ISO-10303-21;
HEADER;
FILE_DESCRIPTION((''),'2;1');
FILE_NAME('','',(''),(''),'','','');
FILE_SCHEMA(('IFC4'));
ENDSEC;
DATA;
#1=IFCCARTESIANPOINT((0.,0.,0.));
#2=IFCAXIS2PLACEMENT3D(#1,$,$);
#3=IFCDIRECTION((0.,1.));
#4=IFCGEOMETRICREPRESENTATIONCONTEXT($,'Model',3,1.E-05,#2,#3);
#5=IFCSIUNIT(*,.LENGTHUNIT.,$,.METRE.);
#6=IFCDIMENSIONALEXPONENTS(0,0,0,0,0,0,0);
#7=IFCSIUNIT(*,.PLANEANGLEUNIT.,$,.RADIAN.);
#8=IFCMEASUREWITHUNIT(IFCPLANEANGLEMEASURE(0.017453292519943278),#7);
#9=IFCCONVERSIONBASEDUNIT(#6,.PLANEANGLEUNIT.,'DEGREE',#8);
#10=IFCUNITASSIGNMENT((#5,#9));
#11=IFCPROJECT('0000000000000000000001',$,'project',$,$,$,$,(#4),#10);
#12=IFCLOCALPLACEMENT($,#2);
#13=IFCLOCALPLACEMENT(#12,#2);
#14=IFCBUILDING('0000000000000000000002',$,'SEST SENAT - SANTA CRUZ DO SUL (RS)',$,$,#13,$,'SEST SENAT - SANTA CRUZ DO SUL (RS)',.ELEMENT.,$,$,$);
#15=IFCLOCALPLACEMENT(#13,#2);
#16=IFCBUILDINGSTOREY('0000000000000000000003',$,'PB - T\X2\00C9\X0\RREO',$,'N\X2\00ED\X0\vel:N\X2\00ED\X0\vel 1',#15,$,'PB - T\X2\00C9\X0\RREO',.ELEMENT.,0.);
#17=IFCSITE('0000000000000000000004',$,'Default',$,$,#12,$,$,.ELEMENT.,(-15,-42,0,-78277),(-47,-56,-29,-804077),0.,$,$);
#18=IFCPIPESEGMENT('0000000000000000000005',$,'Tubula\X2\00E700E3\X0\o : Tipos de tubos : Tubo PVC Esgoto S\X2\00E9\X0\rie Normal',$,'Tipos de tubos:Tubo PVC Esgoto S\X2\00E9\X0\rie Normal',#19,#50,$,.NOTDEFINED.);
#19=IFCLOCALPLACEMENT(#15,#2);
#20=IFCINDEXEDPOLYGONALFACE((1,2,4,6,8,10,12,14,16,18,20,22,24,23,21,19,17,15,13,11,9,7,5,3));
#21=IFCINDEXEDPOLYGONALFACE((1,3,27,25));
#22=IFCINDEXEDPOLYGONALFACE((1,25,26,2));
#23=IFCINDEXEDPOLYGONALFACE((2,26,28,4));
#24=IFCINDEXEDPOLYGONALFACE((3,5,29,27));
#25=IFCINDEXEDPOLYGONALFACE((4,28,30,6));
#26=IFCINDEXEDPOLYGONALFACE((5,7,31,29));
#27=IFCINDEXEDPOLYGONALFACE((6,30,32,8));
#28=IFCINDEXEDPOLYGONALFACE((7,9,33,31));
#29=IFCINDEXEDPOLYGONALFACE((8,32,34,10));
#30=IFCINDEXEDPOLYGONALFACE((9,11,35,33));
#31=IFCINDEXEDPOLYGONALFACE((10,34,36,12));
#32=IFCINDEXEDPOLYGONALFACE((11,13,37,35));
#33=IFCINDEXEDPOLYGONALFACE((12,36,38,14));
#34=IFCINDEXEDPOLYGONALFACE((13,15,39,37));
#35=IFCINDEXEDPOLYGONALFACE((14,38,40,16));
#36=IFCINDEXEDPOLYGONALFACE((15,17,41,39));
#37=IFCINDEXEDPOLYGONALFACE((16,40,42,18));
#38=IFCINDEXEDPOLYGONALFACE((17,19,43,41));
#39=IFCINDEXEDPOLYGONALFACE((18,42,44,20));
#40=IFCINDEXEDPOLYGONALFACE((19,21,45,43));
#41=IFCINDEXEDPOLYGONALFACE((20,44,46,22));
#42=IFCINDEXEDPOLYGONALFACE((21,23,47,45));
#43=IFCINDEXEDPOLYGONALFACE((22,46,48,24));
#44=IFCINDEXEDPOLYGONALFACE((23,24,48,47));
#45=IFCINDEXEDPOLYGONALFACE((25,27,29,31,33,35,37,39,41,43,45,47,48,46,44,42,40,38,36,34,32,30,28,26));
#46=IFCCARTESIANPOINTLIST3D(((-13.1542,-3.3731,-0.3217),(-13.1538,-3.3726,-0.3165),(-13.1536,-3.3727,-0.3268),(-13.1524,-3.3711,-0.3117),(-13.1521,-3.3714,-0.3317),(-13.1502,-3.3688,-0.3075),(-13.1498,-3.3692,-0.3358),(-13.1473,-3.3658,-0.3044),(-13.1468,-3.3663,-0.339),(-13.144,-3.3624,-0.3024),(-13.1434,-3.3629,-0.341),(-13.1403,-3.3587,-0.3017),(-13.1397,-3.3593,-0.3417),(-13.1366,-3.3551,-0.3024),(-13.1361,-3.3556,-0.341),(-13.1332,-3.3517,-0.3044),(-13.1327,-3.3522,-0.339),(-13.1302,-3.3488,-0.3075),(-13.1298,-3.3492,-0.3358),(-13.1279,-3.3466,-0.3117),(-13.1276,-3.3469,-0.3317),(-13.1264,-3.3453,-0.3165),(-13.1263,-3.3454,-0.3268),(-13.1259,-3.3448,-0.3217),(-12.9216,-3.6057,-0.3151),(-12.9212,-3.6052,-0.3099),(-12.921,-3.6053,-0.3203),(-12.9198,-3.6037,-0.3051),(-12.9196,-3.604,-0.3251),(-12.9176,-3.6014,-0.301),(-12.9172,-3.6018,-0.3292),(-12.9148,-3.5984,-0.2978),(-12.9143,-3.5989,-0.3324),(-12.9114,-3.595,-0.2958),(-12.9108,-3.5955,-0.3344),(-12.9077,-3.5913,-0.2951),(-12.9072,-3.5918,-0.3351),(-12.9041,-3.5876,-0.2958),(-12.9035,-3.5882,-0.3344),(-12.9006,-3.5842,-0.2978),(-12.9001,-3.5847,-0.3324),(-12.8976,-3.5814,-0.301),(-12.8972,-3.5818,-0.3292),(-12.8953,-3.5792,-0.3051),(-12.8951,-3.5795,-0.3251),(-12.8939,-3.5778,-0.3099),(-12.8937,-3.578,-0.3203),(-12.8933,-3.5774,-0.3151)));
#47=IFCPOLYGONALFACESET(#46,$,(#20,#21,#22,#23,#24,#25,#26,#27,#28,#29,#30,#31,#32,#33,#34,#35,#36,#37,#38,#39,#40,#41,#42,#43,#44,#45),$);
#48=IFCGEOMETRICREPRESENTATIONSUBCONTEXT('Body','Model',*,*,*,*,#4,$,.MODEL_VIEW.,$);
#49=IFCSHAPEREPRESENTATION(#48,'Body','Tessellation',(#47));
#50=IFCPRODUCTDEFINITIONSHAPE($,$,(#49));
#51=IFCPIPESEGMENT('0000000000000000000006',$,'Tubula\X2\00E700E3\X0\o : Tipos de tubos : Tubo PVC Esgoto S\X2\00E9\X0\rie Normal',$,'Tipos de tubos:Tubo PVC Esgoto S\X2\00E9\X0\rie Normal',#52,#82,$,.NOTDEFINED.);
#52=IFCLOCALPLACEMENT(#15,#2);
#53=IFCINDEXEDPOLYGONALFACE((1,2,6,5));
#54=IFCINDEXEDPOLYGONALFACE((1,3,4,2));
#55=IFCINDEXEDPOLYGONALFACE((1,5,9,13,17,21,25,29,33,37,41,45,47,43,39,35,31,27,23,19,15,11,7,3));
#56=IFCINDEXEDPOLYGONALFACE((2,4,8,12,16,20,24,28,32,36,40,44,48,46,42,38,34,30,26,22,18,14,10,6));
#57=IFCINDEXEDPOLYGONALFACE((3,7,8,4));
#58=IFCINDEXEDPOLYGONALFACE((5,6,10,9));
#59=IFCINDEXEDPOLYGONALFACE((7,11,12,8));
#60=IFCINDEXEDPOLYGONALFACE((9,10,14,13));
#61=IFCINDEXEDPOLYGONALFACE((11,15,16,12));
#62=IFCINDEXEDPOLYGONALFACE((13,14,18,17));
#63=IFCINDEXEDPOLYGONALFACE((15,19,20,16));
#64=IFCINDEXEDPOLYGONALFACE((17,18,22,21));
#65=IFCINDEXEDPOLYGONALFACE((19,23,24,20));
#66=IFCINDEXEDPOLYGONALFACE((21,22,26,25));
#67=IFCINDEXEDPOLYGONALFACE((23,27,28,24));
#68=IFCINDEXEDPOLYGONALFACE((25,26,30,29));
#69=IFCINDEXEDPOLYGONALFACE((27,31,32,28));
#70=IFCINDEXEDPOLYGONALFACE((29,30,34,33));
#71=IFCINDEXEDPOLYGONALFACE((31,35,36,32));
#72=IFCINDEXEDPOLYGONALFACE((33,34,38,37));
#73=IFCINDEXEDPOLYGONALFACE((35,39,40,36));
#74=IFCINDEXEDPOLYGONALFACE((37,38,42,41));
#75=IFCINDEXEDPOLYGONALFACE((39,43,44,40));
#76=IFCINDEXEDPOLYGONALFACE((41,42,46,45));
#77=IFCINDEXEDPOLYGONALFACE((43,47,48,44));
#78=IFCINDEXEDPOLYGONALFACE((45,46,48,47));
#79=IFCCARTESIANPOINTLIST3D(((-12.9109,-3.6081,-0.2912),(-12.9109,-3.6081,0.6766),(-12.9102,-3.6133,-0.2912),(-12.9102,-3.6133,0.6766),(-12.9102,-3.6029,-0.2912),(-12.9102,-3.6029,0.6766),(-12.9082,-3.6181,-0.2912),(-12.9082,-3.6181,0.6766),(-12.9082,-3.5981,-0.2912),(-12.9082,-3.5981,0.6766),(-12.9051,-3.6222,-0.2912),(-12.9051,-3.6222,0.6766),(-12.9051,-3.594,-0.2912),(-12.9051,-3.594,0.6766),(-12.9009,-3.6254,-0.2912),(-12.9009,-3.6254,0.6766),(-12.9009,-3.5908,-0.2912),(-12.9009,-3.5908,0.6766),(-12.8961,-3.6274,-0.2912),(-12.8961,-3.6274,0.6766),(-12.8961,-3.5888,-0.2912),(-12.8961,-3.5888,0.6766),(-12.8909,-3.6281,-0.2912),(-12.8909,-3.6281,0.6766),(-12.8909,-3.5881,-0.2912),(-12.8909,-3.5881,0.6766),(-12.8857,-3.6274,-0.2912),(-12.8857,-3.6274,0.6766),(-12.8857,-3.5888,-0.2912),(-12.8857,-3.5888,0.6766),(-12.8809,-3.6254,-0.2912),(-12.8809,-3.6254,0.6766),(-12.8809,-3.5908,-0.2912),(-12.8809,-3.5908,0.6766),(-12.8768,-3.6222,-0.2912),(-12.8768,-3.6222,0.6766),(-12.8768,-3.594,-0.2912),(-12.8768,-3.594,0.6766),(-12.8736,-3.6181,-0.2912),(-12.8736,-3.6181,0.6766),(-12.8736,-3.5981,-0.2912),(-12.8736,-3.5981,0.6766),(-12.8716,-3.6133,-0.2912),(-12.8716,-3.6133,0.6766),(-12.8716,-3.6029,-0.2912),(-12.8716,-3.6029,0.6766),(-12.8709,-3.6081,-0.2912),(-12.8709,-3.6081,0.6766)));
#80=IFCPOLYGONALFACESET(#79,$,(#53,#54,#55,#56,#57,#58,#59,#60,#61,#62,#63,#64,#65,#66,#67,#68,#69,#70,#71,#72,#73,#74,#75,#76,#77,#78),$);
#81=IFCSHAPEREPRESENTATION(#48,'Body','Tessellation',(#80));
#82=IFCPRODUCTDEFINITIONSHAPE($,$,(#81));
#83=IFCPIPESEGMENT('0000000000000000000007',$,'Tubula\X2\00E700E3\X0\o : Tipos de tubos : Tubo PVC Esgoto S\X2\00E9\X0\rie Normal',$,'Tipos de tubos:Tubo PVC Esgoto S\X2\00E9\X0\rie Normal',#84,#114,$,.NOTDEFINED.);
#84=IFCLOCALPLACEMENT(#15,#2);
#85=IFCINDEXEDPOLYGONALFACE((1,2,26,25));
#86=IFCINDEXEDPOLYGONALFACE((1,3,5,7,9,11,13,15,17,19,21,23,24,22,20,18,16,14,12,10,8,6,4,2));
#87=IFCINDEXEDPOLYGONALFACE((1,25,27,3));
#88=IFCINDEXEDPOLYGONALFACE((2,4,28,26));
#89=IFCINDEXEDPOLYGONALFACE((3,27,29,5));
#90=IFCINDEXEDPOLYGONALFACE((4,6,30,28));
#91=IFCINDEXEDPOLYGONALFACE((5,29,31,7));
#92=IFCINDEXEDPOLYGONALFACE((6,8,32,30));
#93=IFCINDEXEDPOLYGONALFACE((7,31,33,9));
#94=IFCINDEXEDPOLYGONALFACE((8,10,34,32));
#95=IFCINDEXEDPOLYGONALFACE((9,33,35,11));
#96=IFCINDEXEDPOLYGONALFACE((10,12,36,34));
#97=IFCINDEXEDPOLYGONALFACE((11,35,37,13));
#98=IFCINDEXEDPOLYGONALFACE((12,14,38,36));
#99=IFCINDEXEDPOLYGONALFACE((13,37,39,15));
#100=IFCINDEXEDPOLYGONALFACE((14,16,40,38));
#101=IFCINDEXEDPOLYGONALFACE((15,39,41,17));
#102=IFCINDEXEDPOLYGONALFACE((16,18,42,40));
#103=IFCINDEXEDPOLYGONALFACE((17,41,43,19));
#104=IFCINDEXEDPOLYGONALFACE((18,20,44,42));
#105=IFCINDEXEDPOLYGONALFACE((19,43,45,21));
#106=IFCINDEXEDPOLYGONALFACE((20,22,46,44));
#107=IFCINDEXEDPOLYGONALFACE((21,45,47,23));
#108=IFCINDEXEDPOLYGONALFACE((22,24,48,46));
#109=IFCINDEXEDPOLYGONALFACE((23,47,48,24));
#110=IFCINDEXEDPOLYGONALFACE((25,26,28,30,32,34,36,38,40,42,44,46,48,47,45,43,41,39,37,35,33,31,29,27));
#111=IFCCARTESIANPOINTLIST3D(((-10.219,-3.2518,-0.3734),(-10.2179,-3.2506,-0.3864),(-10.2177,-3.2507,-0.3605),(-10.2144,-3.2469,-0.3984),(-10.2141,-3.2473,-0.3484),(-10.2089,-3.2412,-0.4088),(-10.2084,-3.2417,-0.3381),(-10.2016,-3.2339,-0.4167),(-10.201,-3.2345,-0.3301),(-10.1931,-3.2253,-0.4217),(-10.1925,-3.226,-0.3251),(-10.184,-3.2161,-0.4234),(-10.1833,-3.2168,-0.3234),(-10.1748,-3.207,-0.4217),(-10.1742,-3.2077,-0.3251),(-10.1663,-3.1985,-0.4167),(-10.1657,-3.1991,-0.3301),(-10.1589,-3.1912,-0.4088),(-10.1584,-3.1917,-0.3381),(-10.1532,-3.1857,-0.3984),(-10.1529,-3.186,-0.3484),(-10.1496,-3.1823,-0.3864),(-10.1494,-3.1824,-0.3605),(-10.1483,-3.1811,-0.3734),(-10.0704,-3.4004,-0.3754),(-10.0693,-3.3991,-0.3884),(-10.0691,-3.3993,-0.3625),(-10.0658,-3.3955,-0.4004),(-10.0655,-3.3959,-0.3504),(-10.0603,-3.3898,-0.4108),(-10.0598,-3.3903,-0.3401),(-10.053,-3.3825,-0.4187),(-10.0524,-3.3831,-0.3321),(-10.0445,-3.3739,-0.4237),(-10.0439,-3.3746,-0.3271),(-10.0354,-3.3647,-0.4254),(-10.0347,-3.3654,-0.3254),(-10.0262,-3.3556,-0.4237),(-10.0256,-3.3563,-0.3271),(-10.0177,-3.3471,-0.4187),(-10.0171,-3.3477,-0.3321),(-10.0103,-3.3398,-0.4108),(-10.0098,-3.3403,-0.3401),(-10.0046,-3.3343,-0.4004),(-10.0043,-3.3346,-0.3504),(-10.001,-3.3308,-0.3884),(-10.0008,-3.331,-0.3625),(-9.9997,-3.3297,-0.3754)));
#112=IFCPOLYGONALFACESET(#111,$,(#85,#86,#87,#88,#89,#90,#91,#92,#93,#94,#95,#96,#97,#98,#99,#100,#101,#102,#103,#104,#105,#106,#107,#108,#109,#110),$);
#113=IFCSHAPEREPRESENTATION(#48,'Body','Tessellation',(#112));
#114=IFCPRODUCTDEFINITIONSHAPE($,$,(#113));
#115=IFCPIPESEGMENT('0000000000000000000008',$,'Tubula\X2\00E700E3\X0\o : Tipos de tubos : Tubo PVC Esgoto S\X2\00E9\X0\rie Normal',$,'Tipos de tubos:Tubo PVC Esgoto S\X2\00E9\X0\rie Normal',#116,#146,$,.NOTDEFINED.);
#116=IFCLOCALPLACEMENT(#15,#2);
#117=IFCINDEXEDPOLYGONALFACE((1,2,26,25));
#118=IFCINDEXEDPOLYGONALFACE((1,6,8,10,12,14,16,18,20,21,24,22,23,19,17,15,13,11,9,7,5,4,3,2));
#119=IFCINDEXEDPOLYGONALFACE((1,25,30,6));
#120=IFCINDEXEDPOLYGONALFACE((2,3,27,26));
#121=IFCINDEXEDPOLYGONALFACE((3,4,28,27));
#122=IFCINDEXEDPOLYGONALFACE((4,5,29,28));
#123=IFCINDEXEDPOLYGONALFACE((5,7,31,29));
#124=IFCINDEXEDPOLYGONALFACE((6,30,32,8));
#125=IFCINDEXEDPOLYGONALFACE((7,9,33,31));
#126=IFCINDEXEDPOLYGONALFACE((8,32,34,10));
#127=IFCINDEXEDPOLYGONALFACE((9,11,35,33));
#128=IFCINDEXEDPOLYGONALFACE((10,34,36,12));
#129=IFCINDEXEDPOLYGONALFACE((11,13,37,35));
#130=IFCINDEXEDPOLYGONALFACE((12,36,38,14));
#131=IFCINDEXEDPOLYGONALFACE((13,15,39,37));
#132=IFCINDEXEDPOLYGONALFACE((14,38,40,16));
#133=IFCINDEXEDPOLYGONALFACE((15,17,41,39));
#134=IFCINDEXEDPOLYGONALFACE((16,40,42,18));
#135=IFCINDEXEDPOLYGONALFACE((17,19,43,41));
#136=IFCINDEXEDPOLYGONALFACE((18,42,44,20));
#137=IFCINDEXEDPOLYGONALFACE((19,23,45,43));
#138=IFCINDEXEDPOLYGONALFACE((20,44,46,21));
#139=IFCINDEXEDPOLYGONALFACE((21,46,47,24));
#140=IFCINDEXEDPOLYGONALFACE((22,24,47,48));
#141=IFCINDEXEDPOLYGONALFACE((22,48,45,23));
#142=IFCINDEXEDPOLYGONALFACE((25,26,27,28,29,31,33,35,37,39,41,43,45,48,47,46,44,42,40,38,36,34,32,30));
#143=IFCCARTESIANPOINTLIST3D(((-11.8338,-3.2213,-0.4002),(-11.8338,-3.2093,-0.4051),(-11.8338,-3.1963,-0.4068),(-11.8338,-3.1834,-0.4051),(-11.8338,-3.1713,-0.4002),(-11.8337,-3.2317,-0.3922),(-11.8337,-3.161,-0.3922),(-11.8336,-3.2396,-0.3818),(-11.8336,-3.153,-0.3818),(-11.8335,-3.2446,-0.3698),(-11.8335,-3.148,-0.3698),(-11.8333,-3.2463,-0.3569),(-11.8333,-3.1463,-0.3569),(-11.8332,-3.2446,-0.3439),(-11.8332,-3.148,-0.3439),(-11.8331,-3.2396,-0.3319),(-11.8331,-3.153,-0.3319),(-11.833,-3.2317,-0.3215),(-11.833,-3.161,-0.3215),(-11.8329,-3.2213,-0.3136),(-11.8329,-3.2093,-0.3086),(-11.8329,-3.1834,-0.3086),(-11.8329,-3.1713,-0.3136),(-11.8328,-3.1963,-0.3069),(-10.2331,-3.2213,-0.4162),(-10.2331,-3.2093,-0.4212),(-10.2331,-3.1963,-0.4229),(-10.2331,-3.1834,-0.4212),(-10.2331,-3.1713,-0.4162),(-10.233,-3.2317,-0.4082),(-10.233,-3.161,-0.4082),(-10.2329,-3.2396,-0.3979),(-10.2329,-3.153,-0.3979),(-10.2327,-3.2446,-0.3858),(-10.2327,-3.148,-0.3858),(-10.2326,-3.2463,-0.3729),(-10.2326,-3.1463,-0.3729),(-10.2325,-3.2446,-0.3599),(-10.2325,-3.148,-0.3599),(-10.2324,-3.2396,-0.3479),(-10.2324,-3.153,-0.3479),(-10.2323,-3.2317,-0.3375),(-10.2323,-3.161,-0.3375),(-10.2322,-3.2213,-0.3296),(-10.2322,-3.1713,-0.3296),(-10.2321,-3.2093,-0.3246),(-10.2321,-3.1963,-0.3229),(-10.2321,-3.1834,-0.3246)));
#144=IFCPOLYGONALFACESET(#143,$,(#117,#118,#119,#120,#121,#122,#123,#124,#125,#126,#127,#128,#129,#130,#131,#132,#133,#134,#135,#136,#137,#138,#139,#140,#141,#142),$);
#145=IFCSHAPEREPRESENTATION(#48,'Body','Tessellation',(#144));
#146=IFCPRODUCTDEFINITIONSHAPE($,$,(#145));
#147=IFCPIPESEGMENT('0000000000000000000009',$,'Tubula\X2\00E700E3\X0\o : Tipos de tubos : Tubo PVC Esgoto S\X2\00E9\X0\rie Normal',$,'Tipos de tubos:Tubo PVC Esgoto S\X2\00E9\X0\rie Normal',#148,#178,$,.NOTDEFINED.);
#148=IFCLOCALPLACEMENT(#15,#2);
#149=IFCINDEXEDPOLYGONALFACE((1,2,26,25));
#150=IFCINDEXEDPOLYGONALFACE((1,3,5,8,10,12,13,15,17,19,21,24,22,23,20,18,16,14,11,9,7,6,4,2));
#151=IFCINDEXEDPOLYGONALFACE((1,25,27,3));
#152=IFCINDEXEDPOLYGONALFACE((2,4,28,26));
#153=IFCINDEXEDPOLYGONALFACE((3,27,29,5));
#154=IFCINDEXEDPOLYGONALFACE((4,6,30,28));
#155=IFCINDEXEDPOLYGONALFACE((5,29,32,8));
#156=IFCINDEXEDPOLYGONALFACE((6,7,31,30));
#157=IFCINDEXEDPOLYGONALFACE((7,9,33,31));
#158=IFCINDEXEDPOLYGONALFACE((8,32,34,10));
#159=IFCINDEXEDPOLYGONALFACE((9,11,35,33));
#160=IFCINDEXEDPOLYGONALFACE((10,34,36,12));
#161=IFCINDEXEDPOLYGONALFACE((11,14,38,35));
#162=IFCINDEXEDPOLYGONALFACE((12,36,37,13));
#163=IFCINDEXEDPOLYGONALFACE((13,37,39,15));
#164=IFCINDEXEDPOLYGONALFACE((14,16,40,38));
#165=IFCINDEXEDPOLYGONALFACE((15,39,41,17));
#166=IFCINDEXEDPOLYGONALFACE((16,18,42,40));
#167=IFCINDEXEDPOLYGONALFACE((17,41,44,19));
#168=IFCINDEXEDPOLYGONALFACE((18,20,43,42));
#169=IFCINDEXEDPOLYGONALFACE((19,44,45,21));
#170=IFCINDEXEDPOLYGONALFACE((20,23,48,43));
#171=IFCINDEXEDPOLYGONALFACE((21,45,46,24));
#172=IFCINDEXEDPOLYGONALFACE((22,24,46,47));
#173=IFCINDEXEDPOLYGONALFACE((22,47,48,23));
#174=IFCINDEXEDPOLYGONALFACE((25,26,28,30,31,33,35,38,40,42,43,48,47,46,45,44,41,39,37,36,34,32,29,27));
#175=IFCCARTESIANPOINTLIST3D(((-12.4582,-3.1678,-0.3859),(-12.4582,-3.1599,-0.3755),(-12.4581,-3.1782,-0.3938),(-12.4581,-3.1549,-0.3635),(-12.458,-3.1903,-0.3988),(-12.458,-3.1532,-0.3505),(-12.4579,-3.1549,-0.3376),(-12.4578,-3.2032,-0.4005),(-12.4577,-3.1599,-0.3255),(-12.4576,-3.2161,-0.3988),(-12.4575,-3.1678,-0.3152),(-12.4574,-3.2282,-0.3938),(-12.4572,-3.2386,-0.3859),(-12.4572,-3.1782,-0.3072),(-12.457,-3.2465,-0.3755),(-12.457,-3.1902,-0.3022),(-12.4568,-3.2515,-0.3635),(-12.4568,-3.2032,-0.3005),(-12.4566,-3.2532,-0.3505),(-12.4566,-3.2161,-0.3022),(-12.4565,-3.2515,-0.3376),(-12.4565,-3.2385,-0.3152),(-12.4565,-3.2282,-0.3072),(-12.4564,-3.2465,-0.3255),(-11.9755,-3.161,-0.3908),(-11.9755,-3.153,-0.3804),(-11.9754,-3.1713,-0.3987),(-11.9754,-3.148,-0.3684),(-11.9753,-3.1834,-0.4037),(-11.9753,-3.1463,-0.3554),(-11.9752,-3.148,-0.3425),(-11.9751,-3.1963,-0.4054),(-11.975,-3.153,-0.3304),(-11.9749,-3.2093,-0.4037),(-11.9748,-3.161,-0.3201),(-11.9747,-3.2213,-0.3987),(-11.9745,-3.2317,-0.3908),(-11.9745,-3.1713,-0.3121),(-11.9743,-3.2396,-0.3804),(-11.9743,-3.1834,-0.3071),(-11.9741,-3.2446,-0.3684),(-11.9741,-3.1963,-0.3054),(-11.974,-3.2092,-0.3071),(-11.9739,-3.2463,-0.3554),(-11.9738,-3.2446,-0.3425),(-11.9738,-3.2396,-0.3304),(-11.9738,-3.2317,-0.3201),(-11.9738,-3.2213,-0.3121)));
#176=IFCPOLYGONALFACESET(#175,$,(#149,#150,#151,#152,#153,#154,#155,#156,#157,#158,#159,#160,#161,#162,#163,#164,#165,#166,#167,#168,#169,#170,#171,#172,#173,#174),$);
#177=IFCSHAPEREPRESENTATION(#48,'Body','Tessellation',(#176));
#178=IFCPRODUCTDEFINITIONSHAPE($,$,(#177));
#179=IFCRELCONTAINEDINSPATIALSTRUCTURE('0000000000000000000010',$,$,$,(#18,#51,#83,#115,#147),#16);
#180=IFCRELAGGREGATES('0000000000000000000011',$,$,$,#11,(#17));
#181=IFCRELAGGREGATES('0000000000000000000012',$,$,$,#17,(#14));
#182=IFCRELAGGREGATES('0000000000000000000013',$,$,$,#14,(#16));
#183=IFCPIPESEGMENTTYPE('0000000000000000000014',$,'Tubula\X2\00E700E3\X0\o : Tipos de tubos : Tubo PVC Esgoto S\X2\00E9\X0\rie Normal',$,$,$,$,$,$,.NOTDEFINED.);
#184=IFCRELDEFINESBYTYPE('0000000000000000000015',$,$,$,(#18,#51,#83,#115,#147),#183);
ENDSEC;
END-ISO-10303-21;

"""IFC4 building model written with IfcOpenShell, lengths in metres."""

from ifc_helpers import new_model, entity, si_unit, converted_unit, direction, frame, origin, place, context, subcontext, project, spatial, arc, indexed_curve, outline, extrude, type_object, element, save


model = new_model("IFC4")

# Units and contexts
model_context = context("Model", 3, precision=1e-05, world=origin(), true_north=direction((0.0, 1.0)))
body_context = subcontext(model_context, "Body", "Model", "MODEL_VIEW")
ifc_project = project(units=[si_unit("LENGTHUNIT", "METRE"), converted_unit("PLANEANGLEUNIT", "DEGREE", entity("IfcPlaneAngleMeasure", 0.017453292519943278), si_unit("PLANEANGLEUNIT", "RADIAN"), dimensions=[0, 0, 0, 0, 0, 0, 0])], contexts=[model_context])

# Site, building, storey
site_placement = place(None, origin())
site = spatial("IfcSite", under=ifc_project, at=site_placement, Name="Default", CompositionType="ELEMENT", RefLatitude=(-15, -42, 0, -78277), RefLongitude=(-47, -56, -29, -804077), RefElevation=0.0)
building_placement = place(site_placement, origin())
building = spatial("IfcBuilding", under=site, at=building_placement, Name="SEST SENAT - SANTA CRUZ DO SUL (RS)", LongName="SEST SENAT - SANTA CRUZ DO SUL (RS)", CompositionType="ELEMENT")
storey_placement = place(building_placement, origin())
storey = spatial("IfcBuildingStorey", under=building, at=storey_placement, Name="PB - TÉRREO", ObjectType="Nível:Nível 1", LongName="PB - TÉRREO", CompositionType="ELEMENT", Elevation=0.0)

# Pipe segments
pipe_segment_type_1 = type_object("IfcPipeSegmentType", Name="Tubulação : Tipos de tubos : Tubo PVC Esgoto Série Normal", PredefinedType="NOTDEFINED")
pipe_segment_1_placement = place(storey_placement, frame((-13.1558, -3.6073, -0.3433)))
element("IfcPipeSegment", 1, at=pipe_segment_1_placement, inside=storey, type_object=pipe_segment_type_1, Name="Tubulação : Tipos de tubos : Tubo PVC Esgoto Série Normal", ObjectType="Tipos de tubos:Tubo PVC Esgoto Série Normal", PredefinedType="NOTDEFINED", context=body_context, shape_type="SweptSolid", body=[
    extrude(outline(indexed_curve([(0.02, 0.0), (0.0141, 0.0141), (0.0, 0.02), (-0.0141, 0.0141), (-0.02, 0.0), (-0.0141, -0.0141), (0.0, -0.02), (0.0141, -0.0141)], segments=[arc(1, 2, 3), arc(3, 4, 5), arc(5, 6, 7), arc(7, 8, 1)], self_intersect=False)), frame((0.2483, 0.0157, 0.0282), z_axis=(-0.706965, 0.706965, -0.019996), x_axis=(-0.707107, -0.707107, 0.0)), (0.0, 0.0, 1.0), 0.329),
])
pipe_segment_2_placement = place(storey_placement, frame((-12.9125, -3.6297, -0.2912)))
element("IfcPipeSegment", 2, at=pipe_segment_2_placement, inside=storey, type_object=pipe_segment_type_1, Name="Tubulação : Tipos de tubos : Tubo PVC Esgoto Série Normal", ObjectType="Tipos de tubos:Tubo PVC Esgoto Série Normal", PredefinedType="NOTDEFINED", context=body_context, shape_type="SweptSolid", body=[
    extrude(outline(indexed_curve([(0.02, 0.0), (0.0141, 0.0141), (0.0, 0.02), (-0.0141, 0.0141), (-0.02, 0.0), (-0.0141, -0.0141), (0.0, -0.02), (0.0141, -0.0141)], segments=[arc(1, 2, 3), arc(3, 4, 5), arc(5, 6, 7), arc(7, 8, 1)], self_intersect=False)), frame((0.0216, 0.0216, 0.0), z_axis=(0.0, 0.0, 1.0), x_axis=(-1.0, 0.0, 0.0)), (0.0, 0.0, 1.0), 0.9679),
])
pipe_segment_3_placement = place(storey_placement, frame((-10.2206, -3.402, -0.3218)))
element("IfcPipeSegment", 3, at=pipe_segment_3_placement, inside=storey, type_object=pipe_segment_type_1, Name="Tubulação : Tipos de tubos : Tubo PVC Esgoto Série Normal", ObjectType="Tipos de tubos:Tubo PVC Esgoto Série Normal", PredefinedType="NOTDEFINED", context=body_context, shape_type="SweptSolid", body=[
    extrude(outline(indexed_curve([(0.05, 0.0), (0.0354, 0.0354), (0.0, 0.05), (-0.0354, 0.0354), (-0.05, 0.0), (-0.0354, -0.0354), (0.0, -0.05), (0.0354, -0.0354)], segments=[arc(1, 2, 3), arc(3, 4, 5), arc(5, 6, 7), arc(7, 8, 1)], self_intersect=False)), frame((0.1855, 0.037, -0.0536), z_axis=(-0.707074, 0.707074, 0.009613), x_axis=(-0.707107, -0.707107, 0.0)), (0.0, 0.0, 1.0), 0.2102),
])
pipe_segment_4_placement = place(storey_placement, frame((-11.8354, -3.2479, -0.3053)))
element("IfcPipeSegment", 4, at=pipe_segment_4_placement, inside=storey, type_object=pipe_segment_type_1, Name="Tubulação : Tipos de tubos : Tubo PVC Esgoto Série Normal", ObjectType="Tipos de tubos:Tubo PVC Esgoto Série Normal", PredefinedType="NOTDEFINED", context=body_context, shape_type="SweptSolid", body=[
    extrude(outline(indexed_curve([(0.05, 0.0), (0.0354, 0.0354), (0.0, 0.05), (-0.0354, 0.0354), (-0.05, 0.0), (-0.0354, -0.0354), (0.0, -0.05), (0.0354, -0.0354)], segments=[arc(1, 2, 3), arc(3, 4, 5), arc(5, 6, 7), arc(7, 8, 1)], self_intersect=False)), frame((0.0021, 0.0516, -0.0516), z_axis=(0.99995, 0.0, -0.01), x_axis=(0.0, 1.0, 0.0)), (0.0, 0.0, 1.0), 1.6008),
])
pipe_segment_5_placement = place(storey_placement, frame((-12.4598, -3.2548, -0.2989)))
element("IfcPipeSegment", 5, at=pipe_segment_5_placement, inside=storey, type_object=pipe_segment_type_1, Name="Tubulação : Tipos de tubos : Tubo PVC Esgoto Série Normal", ObjectType="Tipos de tubos:Tubo PVC Esgoto Série Normal", PredefinedType="NOTDEFINED", context=body_context, shape_type="SweptSolid", body=[
    extrude(outline(indexed_curve([(0.05, 0.0), (0.0354, 0.0354), (0.0, 0.05), (-0.0354, 0.0354), (-0.05, 0.0), (-0.0354, -0.0354), (0.0, -0.05), (0.0354, -0.0354)], segments=[arc(1, 2, 3), arc(3, 4, 5), arc(5, 6, 7), arc(7, 8, 1)], self_intersect=False)), frame((0.4852, 0.0585, -0.0565), z_axis=(-0.999846, -0.014262, 0.01018), x_axis=(0.014262, -0.999898, 0.0)), (0.0, 0.0, 1.0), 0.4828),
])

save(model, "model.ifc")
